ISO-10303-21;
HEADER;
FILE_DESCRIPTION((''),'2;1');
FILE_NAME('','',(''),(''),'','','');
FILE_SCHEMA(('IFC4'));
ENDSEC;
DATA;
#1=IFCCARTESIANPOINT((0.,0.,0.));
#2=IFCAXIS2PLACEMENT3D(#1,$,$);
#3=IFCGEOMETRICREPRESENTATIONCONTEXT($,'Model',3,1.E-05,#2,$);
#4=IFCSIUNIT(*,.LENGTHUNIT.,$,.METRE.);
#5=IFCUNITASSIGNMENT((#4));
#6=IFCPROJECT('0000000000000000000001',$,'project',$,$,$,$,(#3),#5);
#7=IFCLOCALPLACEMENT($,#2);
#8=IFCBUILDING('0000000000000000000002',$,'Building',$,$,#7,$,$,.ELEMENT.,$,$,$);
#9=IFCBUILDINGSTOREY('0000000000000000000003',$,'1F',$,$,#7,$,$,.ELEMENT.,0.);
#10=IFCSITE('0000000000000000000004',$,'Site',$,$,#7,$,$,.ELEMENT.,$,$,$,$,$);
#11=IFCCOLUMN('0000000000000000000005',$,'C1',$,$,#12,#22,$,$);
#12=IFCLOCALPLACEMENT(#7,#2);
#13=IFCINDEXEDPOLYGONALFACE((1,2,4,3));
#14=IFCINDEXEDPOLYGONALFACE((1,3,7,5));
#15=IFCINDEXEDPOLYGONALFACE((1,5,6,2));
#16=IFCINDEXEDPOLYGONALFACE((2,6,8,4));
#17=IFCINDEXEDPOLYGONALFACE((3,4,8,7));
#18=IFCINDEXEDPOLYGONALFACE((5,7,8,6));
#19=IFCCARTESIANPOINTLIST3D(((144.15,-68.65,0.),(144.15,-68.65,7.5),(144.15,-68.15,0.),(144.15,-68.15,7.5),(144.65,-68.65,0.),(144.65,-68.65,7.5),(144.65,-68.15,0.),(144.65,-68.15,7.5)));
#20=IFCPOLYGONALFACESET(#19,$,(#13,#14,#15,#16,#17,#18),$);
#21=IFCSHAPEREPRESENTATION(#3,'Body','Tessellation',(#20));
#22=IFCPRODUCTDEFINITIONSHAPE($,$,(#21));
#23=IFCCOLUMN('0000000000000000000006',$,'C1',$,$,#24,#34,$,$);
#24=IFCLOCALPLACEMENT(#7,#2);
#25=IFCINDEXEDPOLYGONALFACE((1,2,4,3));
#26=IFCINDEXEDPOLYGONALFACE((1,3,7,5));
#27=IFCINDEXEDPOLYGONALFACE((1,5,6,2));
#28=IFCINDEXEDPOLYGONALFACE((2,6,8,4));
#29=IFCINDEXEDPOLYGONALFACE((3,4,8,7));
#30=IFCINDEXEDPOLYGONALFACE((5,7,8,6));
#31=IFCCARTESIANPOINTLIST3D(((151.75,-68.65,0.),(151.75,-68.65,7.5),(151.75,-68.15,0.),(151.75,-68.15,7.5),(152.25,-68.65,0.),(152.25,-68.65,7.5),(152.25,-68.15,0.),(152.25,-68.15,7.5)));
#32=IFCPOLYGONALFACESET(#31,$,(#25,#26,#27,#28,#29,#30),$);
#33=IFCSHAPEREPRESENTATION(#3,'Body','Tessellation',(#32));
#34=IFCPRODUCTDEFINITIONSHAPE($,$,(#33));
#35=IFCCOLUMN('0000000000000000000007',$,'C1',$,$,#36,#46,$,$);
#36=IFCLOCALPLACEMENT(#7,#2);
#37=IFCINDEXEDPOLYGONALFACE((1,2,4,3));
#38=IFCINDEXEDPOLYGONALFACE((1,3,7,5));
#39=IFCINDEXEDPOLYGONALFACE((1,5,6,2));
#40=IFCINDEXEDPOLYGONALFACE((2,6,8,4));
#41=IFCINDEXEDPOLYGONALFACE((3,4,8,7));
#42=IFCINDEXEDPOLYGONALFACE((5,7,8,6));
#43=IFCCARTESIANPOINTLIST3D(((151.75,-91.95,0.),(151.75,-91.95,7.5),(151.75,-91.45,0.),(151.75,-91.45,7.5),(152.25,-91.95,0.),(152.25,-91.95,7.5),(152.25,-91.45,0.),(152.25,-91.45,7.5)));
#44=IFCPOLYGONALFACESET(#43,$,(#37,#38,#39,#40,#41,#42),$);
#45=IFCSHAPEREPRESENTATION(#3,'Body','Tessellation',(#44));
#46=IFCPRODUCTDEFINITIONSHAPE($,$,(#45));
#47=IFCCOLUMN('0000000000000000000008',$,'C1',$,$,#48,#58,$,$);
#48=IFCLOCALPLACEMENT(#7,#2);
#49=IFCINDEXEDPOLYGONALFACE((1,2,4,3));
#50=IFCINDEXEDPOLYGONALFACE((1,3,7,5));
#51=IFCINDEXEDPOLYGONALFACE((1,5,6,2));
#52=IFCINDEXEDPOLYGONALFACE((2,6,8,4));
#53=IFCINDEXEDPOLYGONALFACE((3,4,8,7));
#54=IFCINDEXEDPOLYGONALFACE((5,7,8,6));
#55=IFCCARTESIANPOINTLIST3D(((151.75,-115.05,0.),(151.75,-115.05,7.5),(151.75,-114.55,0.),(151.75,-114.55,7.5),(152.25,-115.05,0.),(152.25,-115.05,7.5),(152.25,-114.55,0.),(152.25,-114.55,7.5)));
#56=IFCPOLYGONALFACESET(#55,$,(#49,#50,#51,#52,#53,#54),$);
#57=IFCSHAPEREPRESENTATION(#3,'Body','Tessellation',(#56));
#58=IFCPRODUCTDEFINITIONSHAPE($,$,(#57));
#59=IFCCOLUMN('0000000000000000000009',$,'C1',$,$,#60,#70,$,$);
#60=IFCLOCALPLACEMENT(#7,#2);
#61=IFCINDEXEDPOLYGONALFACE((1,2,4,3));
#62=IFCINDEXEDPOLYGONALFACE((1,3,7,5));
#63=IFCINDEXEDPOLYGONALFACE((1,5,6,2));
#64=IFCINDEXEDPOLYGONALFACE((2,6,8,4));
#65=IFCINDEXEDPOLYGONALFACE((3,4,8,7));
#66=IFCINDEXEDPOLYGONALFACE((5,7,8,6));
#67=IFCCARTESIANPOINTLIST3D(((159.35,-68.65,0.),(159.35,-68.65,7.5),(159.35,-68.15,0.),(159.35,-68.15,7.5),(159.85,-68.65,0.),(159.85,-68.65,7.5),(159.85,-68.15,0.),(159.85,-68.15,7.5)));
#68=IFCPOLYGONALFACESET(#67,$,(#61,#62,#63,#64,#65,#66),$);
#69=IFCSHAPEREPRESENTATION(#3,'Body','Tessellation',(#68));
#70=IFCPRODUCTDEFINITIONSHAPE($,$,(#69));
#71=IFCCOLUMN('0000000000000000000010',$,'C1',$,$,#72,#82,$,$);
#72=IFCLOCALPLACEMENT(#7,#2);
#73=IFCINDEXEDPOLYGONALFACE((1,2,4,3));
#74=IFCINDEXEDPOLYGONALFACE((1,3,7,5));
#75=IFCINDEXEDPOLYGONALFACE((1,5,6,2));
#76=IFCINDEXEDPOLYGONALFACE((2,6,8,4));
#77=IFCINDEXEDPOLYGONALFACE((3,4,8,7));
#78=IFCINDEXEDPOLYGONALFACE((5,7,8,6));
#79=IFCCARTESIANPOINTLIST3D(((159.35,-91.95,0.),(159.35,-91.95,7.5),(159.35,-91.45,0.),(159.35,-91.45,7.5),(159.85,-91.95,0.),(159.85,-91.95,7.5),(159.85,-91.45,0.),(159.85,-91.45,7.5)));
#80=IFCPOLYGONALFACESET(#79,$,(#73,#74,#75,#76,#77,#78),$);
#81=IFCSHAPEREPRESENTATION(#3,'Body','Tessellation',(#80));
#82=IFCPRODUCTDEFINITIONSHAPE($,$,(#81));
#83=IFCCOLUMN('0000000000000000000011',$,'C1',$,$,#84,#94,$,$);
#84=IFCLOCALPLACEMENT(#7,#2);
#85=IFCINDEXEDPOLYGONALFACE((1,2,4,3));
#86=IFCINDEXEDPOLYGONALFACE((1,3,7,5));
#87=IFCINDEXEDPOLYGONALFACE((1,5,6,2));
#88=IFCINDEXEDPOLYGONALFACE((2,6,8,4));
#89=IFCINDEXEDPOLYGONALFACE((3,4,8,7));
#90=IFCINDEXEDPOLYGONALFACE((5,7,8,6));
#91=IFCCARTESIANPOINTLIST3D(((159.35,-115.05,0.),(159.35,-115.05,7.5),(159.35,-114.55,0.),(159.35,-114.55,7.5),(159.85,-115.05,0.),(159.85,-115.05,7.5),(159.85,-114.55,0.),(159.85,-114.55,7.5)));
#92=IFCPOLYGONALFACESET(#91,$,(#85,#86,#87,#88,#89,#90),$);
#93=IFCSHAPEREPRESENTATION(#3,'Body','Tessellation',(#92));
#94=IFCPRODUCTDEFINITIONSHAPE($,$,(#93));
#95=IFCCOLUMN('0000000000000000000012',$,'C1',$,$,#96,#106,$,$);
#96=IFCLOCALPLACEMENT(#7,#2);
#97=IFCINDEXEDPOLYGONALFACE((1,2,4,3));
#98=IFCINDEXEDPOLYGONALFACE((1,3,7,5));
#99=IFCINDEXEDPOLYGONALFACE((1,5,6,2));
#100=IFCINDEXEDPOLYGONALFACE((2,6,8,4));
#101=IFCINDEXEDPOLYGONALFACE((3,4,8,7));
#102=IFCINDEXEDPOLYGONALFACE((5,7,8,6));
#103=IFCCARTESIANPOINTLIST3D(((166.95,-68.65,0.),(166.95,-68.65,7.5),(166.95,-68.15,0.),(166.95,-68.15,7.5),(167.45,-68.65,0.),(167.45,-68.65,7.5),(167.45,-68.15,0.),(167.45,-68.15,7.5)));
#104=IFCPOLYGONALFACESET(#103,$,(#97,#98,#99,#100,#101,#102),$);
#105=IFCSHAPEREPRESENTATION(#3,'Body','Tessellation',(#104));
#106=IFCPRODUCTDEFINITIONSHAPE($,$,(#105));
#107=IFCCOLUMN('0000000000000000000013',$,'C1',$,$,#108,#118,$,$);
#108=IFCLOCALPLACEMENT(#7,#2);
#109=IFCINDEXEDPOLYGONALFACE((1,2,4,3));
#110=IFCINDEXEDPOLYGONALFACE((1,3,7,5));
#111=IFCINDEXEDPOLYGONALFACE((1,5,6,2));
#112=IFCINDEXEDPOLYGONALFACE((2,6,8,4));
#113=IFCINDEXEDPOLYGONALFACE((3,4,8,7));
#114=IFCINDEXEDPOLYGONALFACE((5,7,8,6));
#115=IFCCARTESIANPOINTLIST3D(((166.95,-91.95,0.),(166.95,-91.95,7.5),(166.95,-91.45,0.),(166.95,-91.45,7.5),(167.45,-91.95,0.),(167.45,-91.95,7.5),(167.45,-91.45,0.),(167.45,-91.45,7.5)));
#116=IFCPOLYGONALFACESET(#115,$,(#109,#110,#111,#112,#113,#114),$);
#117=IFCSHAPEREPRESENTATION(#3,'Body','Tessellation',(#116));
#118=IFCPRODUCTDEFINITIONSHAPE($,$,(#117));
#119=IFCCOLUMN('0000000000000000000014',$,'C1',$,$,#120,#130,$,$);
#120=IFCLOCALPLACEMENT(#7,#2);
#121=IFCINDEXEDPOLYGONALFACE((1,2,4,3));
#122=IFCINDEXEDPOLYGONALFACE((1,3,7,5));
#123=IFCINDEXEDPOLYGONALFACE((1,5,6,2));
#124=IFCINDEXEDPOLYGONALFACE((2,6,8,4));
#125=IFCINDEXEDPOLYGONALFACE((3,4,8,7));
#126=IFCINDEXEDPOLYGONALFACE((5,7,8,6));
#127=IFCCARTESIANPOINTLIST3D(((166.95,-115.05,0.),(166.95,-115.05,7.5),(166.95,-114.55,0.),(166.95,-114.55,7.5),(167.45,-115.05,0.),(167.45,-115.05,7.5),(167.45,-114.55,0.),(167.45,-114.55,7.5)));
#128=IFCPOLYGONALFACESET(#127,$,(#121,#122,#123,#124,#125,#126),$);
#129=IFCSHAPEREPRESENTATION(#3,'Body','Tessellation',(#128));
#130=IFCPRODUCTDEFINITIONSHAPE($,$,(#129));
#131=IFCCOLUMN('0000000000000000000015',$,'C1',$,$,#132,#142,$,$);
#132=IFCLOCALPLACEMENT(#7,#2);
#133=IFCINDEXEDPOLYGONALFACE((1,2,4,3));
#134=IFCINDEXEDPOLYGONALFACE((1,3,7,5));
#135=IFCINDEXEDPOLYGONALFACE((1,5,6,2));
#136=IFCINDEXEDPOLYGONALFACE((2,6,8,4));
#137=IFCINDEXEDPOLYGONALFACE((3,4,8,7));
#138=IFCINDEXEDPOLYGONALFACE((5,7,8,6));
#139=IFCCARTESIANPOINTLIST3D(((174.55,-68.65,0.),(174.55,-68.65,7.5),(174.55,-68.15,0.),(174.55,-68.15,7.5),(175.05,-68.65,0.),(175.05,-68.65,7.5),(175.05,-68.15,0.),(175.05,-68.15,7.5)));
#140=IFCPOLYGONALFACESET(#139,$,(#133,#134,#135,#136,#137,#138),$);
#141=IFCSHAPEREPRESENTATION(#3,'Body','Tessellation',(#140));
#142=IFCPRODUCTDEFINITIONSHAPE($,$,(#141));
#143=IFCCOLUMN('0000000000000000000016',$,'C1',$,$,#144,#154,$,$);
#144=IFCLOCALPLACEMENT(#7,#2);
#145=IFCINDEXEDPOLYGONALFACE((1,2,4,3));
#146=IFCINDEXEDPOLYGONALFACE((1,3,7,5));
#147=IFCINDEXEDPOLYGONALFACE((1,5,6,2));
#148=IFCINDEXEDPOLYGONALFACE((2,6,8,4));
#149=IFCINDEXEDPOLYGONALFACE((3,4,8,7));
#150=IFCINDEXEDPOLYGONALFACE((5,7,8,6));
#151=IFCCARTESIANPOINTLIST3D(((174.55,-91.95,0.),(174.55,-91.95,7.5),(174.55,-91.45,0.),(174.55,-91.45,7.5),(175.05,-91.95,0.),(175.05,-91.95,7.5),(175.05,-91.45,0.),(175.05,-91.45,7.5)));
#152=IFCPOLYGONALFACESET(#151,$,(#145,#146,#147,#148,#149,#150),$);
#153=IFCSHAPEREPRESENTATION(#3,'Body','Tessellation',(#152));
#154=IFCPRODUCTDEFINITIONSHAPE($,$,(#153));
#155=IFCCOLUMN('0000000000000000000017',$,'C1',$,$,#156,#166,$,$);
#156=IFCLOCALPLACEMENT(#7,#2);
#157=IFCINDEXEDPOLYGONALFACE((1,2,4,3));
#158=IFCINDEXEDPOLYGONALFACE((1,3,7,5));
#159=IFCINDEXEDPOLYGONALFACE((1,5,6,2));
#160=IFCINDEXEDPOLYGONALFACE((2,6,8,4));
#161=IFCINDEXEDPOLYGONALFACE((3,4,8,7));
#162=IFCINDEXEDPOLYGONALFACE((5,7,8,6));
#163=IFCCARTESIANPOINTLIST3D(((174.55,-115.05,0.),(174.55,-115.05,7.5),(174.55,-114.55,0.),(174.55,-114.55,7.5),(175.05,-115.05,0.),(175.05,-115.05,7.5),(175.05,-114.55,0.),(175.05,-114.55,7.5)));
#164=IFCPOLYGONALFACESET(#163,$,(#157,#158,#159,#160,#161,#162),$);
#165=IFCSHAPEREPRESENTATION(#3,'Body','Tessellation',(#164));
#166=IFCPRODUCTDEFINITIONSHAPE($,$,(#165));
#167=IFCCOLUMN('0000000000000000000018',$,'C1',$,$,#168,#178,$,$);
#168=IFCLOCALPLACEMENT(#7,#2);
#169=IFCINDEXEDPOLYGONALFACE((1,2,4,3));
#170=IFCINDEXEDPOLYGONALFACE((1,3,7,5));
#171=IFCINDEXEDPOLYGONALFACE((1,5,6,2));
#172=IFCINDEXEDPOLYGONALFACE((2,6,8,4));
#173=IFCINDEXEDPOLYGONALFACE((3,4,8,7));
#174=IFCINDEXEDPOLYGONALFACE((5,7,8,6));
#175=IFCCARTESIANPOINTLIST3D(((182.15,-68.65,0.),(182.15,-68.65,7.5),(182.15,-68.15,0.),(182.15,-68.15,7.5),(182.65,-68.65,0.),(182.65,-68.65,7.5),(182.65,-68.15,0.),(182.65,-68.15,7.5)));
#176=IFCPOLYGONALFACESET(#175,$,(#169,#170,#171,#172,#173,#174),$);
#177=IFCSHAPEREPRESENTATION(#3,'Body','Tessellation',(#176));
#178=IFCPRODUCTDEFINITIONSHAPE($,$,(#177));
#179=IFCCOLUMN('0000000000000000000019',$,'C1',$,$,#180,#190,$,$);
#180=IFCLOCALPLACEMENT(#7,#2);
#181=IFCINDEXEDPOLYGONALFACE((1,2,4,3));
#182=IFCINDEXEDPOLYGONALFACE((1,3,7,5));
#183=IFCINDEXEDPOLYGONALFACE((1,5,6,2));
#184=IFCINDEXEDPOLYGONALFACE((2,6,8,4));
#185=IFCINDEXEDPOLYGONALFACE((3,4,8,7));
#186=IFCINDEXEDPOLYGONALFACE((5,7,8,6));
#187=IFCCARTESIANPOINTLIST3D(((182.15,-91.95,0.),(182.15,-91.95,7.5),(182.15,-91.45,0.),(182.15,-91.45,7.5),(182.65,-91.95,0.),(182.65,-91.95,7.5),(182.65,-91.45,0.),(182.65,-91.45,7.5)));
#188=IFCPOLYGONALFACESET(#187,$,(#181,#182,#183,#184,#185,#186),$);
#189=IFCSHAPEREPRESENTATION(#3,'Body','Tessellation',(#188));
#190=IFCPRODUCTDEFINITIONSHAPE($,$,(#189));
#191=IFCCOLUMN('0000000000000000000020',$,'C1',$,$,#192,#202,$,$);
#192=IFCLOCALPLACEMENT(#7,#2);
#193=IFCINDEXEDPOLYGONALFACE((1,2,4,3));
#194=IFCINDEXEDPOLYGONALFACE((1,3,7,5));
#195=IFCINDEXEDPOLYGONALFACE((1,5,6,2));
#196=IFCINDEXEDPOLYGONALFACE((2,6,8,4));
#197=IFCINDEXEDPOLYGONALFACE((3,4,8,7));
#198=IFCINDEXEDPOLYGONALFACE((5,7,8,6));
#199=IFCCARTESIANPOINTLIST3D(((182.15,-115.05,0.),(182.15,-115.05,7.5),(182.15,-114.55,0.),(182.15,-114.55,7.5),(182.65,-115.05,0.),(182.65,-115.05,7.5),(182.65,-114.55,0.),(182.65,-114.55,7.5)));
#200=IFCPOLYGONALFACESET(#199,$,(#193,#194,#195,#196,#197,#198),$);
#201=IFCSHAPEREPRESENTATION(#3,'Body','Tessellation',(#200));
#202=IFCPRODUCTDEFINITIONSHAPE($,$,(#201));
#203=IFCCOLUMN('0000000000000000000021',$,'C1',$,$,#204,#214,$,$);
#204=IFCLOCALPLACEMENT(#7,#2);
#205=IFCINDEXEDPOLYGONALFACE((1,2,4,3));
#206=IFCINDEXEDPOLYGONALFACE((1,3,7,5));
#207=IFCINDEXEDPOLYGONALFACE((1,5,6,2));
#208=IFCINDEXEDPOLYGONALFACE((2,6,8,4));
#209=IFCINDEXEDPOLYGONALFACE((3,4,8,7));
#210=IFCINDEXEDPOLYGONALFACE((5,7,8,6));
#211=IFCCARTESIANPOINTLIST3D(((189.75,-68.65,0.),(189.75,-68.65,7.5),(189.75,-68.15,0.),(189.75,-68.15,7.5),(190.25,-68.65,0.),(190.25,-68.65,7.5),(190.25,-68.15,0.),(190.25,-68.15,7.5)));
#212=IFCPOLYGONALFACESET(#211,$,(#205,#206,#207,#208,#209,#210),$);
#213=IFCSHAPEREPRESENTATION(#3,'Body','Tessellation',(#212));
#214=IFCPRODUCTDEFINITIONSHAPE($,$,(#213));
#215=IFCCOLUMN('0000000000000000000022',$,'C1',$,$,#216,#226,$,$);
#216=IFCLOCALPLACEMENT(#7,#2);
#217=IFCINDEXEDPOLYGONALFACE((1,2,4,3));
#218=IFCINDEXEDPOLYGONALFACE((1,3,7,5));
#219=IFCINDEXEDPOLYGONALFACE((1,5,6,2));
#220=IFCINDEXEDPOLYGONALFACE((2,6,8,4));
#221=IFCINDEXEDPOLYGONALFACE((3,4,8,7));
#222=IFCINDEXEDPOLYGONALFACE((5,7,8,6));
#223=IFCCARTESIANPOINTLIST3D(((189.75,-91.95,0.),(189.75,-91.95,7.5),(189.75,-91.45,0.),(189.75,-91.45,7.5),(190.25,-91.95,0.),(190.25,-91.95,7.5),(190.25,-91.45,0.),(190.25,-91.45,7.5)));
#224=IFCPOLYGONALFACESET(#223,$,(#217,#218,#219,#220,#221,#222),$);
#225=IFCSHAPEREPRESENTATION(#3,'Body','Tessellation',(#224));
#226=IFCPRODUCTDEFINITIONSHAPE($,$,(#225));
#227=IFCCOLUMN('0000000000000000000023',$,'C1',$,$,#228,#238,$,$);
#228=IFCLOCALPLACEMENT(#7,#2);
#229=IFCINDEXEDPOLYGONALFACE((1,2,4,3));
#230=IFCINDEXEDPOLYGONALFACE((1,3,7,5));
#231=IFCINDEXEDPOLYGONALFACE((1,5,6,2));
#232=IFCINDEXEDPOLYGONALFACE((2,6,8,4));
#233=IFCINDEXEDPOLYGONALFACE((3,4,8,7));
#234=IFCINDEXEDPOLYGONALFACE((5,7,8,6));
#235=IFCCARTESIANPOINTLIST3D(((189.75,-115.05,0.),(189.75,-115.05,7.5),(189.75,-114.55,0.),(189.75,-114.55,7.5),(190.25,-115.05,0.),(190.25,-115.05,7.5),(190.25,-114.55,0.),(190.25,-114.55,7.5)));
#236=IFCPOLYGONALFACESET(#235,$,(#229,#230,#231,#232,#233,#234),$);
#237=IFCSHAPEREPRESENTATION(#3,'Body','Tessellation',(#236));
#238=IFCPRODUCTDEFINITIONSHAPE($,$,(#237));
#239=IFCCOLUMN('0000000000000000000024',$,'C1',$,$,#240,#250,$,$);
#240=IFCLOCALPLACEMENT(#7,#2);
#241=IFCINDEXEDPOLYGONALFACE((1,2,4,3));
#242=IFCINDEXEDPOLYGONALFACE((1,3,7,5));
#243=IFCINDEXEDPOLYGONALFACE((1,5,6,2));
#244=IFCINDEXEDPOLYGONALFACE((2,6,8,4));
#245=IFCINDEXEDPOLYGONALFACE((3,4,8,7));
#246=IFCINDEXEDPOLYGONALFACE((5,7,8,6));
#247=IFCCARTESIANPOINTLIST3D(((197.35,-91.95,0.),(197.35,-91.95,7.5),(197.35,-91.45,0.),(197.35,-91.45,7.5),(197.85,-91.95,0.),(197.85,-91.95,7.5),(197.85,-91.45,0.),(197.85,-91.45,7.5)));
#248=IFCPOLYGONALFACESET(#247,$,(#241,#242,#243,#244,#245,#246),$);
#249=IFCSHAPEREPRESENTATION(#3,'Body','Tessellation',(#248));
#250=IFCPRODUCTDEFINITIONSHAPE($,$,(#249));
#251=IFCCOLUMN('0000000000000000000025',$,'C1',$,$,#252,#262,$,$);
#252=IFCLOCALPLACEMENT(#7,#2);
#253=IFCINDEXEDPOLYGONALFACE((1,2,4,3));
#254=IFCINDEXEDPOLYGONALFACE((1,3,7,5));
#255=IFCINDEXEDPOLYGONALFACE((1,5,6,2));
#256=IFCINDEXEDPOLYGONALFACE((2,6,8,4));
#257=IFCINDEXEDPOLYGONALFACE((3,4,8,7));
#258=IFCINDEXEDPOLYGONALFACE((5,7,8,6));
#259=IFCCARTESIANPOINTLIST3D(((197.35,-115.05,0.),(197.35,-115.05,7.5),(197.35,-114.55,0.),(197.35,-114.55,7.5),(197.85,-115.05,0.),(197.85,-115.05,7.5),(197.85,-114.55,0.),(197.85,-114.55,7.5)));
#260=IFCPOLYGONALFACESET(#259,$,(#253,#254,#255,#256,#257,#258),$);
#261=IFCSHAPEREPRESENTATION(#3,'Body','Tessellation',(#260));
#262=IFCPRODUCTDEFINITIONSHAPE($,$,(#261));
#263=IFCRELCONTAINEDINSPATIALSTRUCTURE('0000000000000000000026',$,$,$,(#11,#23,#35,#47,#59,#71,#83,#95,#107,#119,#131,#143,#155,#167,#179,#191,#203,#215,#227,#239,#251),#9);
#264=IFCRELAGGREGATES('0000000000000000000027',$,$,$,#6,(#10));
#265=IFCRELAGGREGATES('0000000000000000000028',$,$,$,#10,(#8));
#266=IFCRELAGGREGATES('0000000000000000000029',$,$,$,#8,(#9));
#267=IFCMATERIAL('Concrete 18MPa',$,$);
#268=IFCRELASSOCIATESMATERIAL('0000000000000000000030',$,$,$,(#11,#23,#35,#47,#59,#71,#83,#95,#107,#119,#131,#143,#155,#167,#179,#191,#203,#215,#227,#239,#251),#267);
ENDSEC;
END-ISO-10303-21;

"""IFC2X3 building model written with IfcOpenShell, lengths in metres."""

from ifc_helpers import new_model, si_unit, frame, origin, origin_2d, place, context, project, spatial, rectangle, extrude, material, element, save


model = new_model("IFC2X3")

# Units and contexts
model_context = context("Model", 3, precision=1e-05, world=origin())
ifc_project = project(units=[si_unit("LENGTHUNIT", "METRE")], contexts=[model_context])

# Site, building, storey
placement = place(None, origin())
site = spatial("IfcSite", under=ifc_project, at=placement, Name="Site", CompositionType="ELEMENT")
building = spatial("IfcBuilding", under=site, at=placement, Name="Building", CompositionType="ELEMENT")
storey = spatial("IfcBuildingStorey", under=building, at=placement, Name="1F", CompositionType="ELEMENT", Elevation=0.0)

# Columns
ifc_material = material(Name="Concrete 18MPa")
for number, where, name in (
    (1, (144.4, -68.4, 0.0), "C1"),
    (2, (152.0, -68.4, 0.0), "C1"),
    (3, (152.0, -91.7, 0.0), "C1"),
    (4, (152.0, -114.8, 0.0), "C1"),
    (5, (159.6, -68.4, 0.0), "C1"),
    (6, (159.6, -91.7, 0.0), "C1"),
    (7, (159.6, -114.8, 0.0), "C1"),
    (8, (167.2, -68.4, 0.0), "C1"),
    (9, (167.2, -91.7, 0.0), "C1"),
    (10, (167.2, -114.8, 0.0), "C1"),
    (11, (174.8, -68.4, 0.0), "C1"),
    (12, (174.8, -91.7, 0.0), "C1"),
    (13, (174.8, -114.8, 0.0), "C1"),
    (14, (182.4, -68.4, 0.0), "C1"),
    (15, (182.4, -91.7, 0.0), "C1"),
    (16, (182.4, -114.8, 0.0), "C1"),
    (17, (190.0, -68.4, 0.0), "C1"),
    (18, (190.0, -91.7, 0.0), "C1"),
    (19, (190.0, -114.8, 0.0), "C1"),
    (20, (197.6, -91.7, 0.0), "C1"),
    (21, (197.6, -114.8, 0.0), "C1"),
):
    element("IfcColumn", number, at=place(None, frame(where)), inside=storey, material=ifc_material, Name=name, context=model_context, shape_type="SweptSolid", body=[
        extrude(rectangle(XDim=0.5, YDim=0.5, at=origin_2d()), origin(), (0.0, 0.0, 1.0), 7.5),
    ])

save(model, "model.ifc")
